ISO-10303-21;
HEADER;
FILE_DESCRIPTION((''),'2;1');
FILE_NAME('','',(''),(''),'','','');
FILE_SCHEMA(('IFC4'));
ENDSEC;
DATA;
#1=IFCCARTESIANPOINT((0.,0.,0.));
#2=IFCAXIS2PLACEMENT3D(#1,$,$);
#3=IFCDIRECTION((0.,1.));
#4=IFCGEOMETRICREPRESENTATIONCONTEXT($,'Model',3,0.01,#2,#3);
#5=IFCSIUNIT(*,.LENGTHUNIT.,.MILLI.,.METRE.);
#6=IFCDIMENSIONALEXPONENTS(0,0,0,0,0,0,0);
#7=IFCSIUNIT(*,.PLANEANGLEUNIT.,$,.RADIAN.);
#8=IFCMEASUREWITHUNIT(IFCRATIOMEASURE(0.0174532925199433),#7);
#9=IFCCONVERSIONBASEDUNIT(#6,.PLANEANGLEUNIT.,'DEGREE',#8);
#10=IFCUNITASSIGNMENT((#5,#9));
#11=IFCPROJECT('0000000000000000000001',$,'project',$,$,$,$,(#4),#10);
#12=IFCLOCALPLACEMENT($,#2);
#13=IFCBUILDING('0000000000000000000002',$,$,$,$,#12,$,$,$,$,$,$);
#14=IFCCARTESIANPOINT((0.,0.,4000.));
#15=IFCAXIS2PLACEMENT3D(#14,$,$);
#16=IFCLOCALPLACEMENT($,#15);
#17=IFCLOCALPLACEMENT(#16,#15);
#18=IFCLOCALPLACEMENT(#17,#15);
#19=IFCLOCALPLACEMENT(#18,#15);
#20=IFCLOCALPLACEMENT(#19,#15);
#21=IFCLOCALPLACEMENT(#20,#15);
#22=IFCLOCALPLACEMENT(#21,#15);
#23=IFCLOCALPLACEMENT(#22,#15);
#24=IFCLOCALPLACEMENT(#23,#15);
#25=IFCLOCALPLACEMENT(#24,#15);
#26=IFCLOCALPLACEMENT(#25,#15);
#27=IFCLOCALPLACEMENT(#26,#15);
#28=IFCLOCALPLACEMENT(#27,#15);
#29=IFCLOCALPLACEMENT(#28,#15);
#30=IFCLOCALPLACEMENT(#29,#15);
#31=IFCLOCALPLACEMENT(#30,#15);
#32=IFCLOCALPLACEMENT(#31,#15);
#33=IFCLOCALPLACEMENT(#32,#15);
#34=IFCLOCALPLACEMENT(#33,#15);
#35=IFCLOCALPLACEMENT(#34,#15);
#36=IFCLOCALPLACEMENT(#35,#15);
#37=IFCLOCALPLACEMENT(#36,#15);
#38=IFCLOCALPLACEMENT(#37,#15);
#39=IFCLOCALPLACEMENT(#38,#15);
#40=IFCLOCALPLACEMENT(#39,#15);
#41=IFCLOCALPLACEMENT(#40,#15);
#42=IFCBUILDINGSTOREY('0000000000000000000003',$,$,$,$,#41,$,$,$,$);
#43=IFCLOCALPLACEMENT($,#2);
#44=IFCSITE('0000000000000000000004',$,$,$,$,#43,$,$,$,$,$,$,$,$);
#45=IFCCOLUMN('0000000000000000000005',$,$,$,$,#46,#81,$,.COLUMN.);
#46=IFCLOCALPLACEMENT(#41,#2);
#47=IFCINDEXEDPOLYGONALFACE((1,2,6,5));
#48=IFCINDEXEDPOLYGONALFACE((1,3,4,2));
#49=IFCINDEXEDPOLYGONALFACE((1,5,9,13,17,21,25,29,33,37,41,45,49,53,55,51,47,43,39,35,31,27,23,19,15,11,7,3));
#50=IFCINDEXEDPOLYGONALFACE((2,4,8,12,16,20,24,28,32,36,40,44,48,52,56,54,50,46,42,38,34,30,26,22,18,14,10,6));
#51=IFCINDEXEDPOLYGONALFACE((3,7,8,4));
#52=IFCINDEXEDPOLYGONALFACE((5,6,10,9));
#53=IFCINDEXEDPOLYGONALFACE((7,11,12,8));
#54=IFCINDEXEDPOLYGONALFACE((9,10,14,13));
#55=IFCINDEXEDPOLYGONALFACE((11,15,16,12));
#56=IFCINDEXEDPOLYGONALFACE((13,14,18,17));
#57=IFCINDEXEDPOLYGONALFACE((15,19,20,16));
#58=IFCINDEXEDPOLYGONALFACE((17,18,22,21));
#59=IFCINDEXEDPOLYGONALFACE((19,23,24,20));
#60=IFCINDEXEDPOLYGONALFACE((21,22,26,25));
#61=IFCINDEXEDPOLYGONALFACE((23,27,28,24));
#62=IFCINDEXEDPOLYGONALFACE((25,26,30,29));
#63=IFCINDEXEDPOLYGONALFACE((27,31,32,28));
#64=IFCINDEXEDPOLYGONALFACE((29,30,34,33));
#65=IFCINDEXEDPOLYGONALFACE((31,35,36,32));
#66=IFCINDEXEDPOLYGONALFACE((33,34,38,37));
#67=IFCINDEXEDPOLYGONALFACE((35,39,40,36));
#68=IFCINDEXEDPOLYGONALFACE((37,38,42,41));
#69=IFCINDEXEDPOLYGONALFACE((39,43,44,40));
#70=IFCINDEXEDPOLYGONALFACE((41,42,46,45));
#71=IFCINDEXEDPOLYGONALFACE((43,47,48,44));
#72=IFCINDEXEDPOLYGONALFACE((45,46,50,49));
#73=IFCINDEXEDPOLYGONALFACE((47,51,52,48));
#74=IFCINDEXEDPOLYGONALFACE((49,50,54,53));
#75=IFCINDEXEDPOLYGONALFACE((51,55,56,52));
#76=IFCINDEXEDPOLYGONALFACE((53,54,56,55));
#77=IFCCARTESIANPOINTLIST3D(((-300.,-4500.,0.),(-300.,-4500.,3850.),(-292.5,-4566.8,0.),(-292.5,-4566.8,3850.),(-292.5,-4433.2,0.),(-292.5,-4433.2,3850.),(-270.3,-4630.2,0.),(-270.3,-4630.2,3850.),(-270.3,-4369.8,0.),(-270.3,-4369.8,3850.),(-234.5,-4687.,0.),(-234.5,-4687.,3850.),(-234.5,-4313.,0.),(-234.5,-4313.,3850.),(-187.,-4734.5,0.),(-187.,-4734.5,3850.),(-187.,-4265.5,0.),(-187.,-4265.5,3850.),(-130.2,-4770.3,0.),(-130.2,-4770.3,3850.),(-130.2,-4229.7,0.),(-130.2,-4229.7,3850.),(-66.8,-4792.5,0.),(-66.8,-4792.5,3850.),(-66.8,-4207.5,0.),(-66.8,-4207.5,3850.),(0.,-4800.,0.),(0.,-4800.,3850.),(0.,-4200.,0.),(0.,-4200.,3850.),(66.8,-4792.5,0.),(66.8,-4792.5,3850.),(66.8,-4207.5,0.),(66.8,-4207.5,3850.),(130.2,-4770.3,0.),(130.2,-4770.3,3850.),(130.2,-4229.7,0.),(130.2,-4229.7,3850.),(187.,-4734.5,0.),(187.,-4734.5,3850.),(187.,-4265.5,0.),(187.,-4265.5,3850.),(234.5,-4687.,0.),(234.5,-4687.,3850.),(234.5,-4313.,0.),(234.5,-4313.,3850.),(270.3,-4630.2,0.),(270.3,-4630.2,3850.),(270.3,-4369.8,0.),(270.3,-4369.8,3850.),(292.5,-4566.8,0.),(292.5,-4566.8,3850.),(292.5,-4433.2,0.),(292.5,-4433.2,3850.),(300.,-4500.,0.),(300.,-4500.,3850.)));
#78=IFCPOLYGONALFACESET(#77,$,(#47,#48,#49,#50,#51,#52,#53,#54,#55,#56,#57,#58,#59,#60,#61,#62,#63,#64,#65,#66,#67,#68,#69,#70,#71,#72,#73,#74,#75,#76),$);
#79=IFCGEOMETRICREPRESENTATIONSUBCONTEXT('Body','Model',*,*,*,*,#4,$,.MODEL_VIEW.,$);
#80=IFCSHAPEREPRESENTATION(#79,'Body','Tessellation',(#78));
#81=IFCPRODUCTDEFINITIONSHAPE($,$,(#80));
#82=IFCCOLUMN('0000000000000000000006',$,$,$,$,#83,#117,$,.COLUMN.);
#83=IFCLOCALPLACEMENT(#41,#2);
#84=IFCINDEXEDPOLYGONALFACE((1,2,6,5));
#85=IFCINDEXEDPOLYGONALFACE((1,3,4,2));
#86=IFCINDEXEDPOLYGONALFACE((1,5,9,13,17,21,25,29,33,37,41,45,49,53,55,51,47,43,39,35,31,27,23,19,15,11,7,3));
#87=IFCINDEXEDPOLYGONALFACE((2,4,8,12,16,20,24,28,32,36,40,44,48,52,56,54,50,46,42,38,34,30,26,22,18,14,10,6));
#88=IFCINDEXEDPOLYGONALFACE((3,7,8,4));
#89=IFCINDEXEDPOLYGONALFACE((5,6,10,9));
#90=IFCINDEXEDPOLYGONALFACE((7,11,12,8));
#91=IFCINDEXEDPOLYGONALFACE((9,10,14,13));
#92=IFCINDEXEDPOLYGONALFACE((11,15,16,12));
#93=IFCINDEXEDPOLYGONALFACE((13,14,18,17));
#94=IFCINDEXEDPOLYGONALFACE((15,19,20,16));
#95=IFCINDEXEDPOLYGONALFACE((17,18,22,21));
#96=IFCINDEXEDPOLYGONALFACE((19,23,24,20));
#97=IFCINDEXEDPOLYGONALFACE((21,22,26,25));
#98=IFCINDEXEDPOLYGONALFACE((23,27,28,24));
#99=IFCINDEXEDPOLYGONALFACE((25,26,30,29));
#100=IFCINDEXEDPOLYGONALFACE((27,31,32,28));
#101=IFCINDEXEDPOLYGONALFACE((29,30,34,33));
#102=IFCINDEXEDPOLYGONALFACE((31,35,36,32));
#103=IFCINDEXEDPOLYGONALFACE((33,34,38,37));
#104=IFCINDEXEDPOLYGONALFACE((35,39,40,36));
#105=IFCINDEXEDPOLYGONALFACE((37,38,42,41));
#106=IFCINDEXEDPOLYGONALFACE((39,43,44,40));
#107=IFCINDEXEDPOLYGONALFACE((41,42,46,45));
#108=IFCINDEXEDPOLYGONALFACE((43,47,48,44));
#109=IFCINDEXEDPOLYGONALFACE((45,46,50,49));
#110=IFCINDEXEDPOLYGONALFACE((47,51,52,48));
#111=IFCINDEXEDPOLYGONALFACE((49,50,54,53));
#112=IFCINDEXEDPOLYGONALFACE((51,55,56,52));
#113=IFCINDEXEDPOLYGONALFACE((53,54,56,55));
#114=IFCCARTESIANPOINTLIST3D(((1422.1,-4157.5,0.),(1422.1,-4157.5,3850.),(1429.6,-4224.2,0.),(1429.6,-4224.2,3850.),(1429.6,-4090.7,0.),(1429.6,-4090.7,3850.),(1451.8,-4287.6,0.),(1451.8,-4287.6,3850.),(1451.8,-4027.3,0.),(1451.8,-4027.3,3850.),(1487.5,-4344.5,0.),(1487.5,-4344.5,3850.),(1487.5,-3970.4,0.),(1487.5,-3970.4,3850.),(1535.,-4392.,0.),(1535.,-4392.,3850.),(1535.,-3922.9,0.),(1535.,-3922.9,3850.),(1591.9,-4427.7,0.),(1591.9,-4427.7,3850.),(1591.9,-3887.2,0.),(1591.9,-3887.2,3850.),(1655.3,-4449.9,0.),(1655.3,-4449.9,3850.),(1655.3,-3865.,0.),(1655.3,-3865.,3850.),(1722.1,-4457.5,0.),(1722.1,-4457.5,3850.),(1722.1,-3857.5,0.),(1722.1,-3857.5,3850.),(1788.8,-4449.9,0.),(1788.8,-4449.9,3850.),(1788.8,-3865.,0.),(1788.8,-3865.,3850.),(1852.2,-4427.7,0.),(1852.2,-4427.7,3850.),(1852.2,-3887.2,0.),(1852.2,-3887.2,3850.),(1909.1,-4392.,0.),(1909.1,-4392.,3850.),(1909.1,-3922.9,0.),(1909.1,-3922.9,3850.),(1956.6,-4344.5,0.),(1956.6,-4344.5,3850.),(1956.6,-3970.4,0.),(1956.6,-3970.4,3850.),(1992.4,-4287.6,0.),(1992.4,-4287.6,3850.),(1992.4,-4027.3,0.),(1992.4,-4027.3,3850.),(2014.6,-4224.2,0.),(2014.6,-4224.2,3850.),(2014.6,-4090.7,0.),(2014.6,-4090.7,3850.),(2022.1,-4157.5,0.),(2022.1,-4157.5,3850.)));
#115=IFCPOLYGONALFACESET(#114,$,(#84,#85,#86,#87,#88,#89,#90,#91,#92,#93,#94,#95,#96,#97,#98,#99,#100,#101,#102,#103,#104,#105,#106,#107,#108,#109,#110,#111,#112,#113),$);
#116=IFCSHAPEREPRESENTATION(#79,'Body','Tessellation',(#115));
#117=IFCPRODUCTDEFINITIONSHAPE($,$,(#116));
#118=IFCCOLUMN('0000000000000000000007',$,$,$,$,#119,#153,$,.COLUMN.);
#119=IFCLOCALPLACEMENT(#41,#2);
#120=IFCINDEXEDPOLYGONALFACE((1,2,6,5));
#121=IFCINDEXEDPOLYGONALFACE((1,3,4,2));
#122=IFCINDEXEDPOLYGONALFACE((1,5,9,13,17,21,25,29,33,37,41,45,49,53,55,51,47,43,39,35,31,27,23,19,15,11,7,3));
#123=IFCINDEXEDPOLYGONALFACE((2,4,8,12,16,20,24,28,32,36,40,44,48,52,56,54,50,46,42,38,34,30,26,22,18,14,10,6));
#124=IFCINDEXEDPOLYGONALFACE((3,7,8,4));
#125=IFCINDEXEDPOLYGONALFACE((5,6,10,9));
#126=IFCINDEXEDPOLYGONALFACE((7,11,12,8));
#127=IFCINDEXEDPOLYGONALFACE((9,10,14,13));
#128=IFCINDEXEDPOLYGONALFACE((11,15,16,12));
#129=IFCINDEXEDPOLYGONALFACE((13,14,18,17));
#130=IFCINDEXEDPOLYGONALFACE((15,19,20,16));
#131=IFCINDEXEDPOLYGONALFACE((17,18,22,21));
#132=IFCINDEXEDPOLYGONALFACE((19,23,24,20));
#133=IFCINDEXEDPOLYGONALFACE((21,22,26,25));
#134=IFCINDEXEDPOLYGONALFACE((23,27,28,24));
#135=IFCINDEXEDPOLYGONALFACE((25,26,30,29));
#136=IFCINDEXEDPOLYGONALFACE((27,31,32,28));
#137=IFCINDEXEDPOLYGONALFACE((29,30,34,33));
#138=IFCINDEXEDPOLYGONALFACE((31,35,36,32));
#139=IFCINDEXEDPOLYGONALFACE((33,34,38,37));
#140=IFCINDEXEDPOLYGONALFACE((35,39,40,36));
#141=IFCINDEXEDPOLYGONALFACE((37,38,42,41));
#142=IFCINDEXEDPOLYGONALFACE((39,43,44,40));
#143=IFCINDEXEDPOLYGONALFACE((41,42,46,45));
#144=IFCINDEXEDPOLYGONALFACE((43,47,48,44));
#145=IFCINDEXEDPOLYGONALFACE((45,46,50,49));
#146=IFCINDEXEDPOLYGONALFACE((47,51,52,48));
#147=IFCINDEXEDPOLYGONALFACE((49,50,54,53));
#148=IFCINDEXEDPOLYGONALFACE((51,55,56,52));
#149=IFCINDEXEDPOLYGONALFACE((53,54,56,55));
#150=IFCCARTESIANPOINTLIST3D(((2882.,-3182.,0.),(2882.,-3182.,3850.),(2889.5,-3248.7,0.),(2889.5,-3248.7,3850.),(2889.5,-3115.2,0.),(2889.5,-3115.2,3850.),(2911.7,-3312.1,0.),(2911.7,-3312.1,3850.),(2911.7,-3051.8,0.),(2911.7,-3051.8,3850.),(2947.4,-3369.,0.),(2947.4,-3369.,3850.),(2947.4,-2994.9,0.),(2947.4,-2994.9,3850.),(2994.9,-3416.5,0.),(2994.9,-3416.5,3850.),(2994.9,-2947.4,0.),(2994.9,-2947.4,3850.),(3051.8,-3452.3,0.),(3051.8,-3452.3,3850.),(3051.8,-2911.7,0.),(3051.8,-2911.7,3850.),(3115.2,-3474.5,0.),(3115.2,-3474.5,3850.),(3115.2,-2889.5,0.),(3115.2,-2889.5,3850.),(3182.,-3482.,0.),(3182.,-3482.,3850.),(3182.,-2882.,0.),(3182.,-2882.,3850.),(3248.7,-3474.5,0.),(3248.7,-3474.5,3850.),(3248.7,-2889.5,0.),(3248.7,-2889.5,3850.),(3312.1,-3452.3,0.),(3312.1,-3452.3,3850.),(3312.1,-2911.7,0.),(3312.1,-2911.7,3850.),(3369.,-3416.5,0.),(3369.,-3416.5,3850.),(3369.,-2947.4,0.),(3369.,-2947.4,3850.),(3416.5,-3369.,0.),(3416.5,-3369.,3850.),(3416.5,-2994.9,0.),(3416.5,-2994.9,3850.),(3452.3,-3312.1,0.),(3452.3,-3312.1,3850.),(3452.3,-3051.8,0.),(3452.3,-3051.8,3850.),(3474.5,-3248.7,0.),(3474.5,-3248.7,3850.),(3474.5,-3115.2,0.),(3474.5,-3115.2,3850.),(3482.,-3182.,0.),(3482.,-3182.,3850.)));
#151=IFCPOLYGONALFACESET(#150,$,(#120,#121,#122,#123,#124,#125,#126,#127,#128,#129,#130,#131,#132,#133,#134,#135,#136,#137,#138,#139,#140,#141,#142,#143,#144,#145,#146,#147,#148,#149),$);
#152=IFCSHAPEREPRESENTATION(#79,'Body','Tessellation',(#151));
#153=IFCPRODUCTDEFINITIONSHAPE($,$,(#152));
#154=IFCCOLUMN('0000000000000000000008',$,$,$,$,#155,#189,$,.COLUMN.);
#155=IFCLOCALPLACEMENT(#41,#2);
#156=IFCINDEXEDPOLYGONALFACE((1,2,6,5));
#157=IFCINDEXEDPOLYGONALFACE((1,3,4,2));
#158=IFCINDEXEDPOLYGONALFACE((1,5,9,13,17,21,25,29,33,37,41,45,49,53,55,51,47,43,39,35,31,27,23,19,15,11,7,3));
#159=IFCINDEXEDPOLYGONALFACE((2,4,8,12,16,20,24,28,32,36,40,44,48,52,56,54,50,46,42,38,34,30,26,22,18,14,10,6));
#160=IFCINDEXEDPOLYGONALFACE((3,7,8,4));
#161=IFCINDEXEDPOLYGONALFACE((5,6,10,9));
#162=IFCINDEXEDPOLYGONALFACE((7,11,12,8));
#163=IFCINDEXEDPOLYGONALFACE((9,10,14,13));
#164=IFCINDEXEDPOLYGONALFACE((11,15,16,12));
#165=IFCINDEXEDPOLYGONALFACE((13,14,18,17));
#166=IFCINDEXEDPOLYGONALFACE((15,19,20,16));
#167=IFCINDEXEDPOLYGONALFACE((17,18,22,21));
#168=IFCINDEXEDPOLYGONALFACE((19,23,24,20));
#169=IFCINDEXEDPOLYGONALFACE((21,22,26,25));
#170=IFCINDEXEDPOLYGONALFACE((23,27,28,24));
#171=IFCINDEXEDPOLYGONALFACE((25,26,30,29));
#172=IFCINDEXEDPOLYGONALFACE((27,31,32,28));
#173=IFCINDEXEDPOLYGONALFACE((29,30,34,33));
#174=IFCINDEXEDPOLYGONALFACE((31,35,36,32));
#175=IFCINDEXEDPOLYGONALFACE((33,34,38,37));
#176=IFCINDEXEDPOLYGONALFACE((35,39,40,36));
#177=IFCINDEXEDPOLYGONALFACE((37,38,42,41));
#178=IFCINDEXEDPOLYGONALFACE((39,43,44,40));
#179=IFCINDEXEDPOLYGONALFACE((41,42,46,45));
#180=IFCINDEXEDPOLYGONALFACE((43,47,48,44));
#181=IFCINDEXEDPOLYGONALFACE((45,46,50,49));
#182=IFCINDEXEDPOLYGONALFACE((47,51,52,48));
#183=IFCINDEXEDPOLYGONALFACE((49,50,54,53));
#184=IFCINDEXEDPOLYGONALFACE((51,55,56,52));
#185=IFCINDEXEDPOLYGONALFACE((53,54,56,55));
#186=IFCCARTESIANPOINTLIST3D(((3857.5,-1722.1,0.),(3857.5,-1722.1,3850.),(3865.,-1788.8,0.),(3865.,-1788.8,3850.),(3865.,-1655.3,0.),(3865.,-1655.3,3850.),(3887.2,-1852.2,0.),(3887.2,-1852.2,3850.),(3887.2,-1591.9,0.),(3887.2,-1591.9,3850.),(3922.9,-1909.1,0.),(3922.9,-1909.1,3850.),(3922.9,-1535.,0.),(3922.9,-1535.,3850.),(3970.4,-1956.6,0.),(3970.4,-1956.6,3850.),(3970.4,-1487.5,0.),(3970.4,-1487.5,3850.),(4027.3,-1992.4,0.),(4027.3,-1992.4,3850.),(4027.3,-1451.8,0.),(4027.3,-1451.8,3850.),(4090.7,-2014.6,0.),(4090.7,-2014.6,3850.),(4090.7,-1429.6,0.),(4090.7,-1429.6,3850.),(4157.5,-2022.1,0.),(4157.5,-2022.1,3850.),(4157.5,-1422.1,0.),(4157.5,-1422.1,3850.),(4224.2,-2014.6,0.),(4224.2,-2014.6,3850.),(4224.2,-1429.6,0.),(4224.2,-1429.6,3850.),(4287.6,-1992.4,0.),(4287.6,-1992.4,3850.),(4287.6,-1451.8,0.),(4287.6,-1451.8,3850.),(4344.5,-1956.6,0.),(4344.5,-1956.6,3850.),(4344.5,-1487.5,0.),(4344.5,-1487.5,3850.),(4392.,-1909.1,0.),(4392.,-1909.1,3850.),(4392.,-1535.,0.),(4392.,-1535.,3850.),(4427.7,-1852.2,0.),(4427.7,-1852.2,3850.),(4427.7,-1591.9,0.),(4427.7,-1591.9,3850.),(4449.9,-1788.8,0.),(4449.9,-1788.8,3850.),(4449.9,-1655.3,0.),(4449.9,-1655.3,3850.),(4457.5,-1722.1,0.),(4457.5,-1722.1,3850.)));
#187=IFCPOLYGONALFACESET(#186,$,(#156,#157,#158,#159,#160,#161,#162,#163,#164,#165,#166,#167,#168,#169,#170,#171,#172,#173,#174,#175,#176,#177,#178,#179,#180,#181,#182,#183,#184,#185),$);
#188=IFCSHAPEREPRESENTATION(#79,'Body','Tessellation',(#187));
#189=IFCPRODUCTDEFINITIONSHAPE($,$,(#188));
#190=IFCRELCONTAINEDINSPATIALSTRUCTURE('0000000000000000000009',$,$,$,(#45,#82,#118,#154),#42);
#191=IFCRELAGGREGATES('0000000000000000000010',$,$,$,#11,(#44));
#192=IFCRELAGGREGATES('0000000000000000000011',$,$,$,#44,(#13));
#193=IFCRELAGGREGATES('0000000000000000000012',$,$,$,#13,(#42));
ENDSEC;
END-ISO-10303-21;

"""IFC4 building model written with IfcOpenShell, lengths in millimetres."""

from ifc_helpers import new_model, entity, si_unit, converted_unit, direction, frame, origin, origin_2d, place, context, subcontext, project, spatial, circle, extrude, element, save


model = new_model("IFC4")

# Units and contexts
model_context = context("Model", 3, precision=0.01, world=origin(), true_north=direction((0.0, 1.0)))
body_context = subcontext(model_context, "Body", "Model", "MODEL_VIEW")
ifc_project = project(units=[si_unit("LENGTHUNIT", "METRE", prefix="MILLI"), converted_unit("PLANEANGLEUNIT", "DEGREE", entity("IfcRatioMeasure", 0.0174532925199433), si_unit("PLANEANGLEUNIT", "RADIAN"), dimensions=[0, 0, 0, 0, 0, 0, 0])], contexts=[model_context])

# Site, building, storey
site_placement = place(None, origin())
site = spatial("IfcSite", under=ifc_project, at=site_placement)
building_placement = place(None, origin())
building = spatial("IfcBuilding", under=site, at=building_placement)
placement_1 = place(None, frame((0.0, 0.0, 4000.0)))
placement_2 = place(placement_1, frame((0.0, 0.0, 4000.0)))
placement_3 = place(placement_2, frame((0.0, 0.0, 4000.0)))
placement_4 = place(placement_3, frame((0.0, 0.0, 4000.0)))
placement_5 = place(placement_4, frame((0.0, 0.0, 4000.0)))
placement_6 = place(placement_5, frame((0.0, 0.0, 4000.0)))
placement_7 = place(placement_6, frame((0.0, 0.0, 4000.0)))
placement_8 = place(placement_7, frame((0.0, 0.0, 4000.0)))
placement_9 = place(placement_8, frame((0.0, 0.0, 4000.0)))
placement_10 = place(placement_9, frame((0.0, 0.0, 4000.0)))
placement_11 = place(placement_10, frame((0.0, 0.0, 4000.0)))
placement_12 = place(placement_11, frame((0.0, 0.0, 4000.0)))
placement_13 = place(placement_12, frame((0.0, 0.0, 4000.0)))
placement_14 = place(placement_13, frame((0.0, 0.0, 4000.0)))
placement_15 = place(placement_14, frame((0.0, 0.0, 4000.0)))
placement_16 = place(placement_15, frame((0.0, 0.0, 4000.0)))
placement_17 = place(placement_16, frame((0.0, 0.0, 4000.0)))
placement_18 = place(placement_17, frame((0.0, 0.0, 4000.0)))
placement_19 = place(placement_18, frame((0.0, 0.0, 4000.0)))
placement_20 = place(placement_19, frame((0.0, 0.0, 4000.0)))
placement_21 = place(placement_20, frame((0.0, 0.0, 4000.0)))
placement_22 = place(placement_21, frame((0.0, 0.0, 4000.0)))
placement_23 = place(placement_22, frame((0.0, 0.0, 4000.0)))
placement_24 = place(placement_23, frame((0.0, 0.0, 4000.0)))
placement_25 = place(placement_24, frame((0.0, 0.0, 4000.0)))
storey_placement = place(placement_25, frame((0.0, 0.0, 4000.0)))
storey = spatial("IfcBuildingStorey", under=building, at=storey_placement)

# Columns
for number, where in (
    (1, (0.0, -4500.0, 0.0)),
    (2, (1722.1, -4157.5, 0.0)),
    (3, (3182.0, -3182.0, 0.0)),
    (4, (4157.5, -1722.1, 0.0)),
):
    element("IfcColumn", number, at=place(storey_placement, frame(where)), inside=storey, PredefinedType="COLUMN", context=body_context, shape_type="SweptSolid", body=[
        extrude(circle(Radius=300.0, at=origin_2d()), origin(), (0.0, 0.0, 1.0), 3850.0),
    ])

save(model, "model.ifc")
